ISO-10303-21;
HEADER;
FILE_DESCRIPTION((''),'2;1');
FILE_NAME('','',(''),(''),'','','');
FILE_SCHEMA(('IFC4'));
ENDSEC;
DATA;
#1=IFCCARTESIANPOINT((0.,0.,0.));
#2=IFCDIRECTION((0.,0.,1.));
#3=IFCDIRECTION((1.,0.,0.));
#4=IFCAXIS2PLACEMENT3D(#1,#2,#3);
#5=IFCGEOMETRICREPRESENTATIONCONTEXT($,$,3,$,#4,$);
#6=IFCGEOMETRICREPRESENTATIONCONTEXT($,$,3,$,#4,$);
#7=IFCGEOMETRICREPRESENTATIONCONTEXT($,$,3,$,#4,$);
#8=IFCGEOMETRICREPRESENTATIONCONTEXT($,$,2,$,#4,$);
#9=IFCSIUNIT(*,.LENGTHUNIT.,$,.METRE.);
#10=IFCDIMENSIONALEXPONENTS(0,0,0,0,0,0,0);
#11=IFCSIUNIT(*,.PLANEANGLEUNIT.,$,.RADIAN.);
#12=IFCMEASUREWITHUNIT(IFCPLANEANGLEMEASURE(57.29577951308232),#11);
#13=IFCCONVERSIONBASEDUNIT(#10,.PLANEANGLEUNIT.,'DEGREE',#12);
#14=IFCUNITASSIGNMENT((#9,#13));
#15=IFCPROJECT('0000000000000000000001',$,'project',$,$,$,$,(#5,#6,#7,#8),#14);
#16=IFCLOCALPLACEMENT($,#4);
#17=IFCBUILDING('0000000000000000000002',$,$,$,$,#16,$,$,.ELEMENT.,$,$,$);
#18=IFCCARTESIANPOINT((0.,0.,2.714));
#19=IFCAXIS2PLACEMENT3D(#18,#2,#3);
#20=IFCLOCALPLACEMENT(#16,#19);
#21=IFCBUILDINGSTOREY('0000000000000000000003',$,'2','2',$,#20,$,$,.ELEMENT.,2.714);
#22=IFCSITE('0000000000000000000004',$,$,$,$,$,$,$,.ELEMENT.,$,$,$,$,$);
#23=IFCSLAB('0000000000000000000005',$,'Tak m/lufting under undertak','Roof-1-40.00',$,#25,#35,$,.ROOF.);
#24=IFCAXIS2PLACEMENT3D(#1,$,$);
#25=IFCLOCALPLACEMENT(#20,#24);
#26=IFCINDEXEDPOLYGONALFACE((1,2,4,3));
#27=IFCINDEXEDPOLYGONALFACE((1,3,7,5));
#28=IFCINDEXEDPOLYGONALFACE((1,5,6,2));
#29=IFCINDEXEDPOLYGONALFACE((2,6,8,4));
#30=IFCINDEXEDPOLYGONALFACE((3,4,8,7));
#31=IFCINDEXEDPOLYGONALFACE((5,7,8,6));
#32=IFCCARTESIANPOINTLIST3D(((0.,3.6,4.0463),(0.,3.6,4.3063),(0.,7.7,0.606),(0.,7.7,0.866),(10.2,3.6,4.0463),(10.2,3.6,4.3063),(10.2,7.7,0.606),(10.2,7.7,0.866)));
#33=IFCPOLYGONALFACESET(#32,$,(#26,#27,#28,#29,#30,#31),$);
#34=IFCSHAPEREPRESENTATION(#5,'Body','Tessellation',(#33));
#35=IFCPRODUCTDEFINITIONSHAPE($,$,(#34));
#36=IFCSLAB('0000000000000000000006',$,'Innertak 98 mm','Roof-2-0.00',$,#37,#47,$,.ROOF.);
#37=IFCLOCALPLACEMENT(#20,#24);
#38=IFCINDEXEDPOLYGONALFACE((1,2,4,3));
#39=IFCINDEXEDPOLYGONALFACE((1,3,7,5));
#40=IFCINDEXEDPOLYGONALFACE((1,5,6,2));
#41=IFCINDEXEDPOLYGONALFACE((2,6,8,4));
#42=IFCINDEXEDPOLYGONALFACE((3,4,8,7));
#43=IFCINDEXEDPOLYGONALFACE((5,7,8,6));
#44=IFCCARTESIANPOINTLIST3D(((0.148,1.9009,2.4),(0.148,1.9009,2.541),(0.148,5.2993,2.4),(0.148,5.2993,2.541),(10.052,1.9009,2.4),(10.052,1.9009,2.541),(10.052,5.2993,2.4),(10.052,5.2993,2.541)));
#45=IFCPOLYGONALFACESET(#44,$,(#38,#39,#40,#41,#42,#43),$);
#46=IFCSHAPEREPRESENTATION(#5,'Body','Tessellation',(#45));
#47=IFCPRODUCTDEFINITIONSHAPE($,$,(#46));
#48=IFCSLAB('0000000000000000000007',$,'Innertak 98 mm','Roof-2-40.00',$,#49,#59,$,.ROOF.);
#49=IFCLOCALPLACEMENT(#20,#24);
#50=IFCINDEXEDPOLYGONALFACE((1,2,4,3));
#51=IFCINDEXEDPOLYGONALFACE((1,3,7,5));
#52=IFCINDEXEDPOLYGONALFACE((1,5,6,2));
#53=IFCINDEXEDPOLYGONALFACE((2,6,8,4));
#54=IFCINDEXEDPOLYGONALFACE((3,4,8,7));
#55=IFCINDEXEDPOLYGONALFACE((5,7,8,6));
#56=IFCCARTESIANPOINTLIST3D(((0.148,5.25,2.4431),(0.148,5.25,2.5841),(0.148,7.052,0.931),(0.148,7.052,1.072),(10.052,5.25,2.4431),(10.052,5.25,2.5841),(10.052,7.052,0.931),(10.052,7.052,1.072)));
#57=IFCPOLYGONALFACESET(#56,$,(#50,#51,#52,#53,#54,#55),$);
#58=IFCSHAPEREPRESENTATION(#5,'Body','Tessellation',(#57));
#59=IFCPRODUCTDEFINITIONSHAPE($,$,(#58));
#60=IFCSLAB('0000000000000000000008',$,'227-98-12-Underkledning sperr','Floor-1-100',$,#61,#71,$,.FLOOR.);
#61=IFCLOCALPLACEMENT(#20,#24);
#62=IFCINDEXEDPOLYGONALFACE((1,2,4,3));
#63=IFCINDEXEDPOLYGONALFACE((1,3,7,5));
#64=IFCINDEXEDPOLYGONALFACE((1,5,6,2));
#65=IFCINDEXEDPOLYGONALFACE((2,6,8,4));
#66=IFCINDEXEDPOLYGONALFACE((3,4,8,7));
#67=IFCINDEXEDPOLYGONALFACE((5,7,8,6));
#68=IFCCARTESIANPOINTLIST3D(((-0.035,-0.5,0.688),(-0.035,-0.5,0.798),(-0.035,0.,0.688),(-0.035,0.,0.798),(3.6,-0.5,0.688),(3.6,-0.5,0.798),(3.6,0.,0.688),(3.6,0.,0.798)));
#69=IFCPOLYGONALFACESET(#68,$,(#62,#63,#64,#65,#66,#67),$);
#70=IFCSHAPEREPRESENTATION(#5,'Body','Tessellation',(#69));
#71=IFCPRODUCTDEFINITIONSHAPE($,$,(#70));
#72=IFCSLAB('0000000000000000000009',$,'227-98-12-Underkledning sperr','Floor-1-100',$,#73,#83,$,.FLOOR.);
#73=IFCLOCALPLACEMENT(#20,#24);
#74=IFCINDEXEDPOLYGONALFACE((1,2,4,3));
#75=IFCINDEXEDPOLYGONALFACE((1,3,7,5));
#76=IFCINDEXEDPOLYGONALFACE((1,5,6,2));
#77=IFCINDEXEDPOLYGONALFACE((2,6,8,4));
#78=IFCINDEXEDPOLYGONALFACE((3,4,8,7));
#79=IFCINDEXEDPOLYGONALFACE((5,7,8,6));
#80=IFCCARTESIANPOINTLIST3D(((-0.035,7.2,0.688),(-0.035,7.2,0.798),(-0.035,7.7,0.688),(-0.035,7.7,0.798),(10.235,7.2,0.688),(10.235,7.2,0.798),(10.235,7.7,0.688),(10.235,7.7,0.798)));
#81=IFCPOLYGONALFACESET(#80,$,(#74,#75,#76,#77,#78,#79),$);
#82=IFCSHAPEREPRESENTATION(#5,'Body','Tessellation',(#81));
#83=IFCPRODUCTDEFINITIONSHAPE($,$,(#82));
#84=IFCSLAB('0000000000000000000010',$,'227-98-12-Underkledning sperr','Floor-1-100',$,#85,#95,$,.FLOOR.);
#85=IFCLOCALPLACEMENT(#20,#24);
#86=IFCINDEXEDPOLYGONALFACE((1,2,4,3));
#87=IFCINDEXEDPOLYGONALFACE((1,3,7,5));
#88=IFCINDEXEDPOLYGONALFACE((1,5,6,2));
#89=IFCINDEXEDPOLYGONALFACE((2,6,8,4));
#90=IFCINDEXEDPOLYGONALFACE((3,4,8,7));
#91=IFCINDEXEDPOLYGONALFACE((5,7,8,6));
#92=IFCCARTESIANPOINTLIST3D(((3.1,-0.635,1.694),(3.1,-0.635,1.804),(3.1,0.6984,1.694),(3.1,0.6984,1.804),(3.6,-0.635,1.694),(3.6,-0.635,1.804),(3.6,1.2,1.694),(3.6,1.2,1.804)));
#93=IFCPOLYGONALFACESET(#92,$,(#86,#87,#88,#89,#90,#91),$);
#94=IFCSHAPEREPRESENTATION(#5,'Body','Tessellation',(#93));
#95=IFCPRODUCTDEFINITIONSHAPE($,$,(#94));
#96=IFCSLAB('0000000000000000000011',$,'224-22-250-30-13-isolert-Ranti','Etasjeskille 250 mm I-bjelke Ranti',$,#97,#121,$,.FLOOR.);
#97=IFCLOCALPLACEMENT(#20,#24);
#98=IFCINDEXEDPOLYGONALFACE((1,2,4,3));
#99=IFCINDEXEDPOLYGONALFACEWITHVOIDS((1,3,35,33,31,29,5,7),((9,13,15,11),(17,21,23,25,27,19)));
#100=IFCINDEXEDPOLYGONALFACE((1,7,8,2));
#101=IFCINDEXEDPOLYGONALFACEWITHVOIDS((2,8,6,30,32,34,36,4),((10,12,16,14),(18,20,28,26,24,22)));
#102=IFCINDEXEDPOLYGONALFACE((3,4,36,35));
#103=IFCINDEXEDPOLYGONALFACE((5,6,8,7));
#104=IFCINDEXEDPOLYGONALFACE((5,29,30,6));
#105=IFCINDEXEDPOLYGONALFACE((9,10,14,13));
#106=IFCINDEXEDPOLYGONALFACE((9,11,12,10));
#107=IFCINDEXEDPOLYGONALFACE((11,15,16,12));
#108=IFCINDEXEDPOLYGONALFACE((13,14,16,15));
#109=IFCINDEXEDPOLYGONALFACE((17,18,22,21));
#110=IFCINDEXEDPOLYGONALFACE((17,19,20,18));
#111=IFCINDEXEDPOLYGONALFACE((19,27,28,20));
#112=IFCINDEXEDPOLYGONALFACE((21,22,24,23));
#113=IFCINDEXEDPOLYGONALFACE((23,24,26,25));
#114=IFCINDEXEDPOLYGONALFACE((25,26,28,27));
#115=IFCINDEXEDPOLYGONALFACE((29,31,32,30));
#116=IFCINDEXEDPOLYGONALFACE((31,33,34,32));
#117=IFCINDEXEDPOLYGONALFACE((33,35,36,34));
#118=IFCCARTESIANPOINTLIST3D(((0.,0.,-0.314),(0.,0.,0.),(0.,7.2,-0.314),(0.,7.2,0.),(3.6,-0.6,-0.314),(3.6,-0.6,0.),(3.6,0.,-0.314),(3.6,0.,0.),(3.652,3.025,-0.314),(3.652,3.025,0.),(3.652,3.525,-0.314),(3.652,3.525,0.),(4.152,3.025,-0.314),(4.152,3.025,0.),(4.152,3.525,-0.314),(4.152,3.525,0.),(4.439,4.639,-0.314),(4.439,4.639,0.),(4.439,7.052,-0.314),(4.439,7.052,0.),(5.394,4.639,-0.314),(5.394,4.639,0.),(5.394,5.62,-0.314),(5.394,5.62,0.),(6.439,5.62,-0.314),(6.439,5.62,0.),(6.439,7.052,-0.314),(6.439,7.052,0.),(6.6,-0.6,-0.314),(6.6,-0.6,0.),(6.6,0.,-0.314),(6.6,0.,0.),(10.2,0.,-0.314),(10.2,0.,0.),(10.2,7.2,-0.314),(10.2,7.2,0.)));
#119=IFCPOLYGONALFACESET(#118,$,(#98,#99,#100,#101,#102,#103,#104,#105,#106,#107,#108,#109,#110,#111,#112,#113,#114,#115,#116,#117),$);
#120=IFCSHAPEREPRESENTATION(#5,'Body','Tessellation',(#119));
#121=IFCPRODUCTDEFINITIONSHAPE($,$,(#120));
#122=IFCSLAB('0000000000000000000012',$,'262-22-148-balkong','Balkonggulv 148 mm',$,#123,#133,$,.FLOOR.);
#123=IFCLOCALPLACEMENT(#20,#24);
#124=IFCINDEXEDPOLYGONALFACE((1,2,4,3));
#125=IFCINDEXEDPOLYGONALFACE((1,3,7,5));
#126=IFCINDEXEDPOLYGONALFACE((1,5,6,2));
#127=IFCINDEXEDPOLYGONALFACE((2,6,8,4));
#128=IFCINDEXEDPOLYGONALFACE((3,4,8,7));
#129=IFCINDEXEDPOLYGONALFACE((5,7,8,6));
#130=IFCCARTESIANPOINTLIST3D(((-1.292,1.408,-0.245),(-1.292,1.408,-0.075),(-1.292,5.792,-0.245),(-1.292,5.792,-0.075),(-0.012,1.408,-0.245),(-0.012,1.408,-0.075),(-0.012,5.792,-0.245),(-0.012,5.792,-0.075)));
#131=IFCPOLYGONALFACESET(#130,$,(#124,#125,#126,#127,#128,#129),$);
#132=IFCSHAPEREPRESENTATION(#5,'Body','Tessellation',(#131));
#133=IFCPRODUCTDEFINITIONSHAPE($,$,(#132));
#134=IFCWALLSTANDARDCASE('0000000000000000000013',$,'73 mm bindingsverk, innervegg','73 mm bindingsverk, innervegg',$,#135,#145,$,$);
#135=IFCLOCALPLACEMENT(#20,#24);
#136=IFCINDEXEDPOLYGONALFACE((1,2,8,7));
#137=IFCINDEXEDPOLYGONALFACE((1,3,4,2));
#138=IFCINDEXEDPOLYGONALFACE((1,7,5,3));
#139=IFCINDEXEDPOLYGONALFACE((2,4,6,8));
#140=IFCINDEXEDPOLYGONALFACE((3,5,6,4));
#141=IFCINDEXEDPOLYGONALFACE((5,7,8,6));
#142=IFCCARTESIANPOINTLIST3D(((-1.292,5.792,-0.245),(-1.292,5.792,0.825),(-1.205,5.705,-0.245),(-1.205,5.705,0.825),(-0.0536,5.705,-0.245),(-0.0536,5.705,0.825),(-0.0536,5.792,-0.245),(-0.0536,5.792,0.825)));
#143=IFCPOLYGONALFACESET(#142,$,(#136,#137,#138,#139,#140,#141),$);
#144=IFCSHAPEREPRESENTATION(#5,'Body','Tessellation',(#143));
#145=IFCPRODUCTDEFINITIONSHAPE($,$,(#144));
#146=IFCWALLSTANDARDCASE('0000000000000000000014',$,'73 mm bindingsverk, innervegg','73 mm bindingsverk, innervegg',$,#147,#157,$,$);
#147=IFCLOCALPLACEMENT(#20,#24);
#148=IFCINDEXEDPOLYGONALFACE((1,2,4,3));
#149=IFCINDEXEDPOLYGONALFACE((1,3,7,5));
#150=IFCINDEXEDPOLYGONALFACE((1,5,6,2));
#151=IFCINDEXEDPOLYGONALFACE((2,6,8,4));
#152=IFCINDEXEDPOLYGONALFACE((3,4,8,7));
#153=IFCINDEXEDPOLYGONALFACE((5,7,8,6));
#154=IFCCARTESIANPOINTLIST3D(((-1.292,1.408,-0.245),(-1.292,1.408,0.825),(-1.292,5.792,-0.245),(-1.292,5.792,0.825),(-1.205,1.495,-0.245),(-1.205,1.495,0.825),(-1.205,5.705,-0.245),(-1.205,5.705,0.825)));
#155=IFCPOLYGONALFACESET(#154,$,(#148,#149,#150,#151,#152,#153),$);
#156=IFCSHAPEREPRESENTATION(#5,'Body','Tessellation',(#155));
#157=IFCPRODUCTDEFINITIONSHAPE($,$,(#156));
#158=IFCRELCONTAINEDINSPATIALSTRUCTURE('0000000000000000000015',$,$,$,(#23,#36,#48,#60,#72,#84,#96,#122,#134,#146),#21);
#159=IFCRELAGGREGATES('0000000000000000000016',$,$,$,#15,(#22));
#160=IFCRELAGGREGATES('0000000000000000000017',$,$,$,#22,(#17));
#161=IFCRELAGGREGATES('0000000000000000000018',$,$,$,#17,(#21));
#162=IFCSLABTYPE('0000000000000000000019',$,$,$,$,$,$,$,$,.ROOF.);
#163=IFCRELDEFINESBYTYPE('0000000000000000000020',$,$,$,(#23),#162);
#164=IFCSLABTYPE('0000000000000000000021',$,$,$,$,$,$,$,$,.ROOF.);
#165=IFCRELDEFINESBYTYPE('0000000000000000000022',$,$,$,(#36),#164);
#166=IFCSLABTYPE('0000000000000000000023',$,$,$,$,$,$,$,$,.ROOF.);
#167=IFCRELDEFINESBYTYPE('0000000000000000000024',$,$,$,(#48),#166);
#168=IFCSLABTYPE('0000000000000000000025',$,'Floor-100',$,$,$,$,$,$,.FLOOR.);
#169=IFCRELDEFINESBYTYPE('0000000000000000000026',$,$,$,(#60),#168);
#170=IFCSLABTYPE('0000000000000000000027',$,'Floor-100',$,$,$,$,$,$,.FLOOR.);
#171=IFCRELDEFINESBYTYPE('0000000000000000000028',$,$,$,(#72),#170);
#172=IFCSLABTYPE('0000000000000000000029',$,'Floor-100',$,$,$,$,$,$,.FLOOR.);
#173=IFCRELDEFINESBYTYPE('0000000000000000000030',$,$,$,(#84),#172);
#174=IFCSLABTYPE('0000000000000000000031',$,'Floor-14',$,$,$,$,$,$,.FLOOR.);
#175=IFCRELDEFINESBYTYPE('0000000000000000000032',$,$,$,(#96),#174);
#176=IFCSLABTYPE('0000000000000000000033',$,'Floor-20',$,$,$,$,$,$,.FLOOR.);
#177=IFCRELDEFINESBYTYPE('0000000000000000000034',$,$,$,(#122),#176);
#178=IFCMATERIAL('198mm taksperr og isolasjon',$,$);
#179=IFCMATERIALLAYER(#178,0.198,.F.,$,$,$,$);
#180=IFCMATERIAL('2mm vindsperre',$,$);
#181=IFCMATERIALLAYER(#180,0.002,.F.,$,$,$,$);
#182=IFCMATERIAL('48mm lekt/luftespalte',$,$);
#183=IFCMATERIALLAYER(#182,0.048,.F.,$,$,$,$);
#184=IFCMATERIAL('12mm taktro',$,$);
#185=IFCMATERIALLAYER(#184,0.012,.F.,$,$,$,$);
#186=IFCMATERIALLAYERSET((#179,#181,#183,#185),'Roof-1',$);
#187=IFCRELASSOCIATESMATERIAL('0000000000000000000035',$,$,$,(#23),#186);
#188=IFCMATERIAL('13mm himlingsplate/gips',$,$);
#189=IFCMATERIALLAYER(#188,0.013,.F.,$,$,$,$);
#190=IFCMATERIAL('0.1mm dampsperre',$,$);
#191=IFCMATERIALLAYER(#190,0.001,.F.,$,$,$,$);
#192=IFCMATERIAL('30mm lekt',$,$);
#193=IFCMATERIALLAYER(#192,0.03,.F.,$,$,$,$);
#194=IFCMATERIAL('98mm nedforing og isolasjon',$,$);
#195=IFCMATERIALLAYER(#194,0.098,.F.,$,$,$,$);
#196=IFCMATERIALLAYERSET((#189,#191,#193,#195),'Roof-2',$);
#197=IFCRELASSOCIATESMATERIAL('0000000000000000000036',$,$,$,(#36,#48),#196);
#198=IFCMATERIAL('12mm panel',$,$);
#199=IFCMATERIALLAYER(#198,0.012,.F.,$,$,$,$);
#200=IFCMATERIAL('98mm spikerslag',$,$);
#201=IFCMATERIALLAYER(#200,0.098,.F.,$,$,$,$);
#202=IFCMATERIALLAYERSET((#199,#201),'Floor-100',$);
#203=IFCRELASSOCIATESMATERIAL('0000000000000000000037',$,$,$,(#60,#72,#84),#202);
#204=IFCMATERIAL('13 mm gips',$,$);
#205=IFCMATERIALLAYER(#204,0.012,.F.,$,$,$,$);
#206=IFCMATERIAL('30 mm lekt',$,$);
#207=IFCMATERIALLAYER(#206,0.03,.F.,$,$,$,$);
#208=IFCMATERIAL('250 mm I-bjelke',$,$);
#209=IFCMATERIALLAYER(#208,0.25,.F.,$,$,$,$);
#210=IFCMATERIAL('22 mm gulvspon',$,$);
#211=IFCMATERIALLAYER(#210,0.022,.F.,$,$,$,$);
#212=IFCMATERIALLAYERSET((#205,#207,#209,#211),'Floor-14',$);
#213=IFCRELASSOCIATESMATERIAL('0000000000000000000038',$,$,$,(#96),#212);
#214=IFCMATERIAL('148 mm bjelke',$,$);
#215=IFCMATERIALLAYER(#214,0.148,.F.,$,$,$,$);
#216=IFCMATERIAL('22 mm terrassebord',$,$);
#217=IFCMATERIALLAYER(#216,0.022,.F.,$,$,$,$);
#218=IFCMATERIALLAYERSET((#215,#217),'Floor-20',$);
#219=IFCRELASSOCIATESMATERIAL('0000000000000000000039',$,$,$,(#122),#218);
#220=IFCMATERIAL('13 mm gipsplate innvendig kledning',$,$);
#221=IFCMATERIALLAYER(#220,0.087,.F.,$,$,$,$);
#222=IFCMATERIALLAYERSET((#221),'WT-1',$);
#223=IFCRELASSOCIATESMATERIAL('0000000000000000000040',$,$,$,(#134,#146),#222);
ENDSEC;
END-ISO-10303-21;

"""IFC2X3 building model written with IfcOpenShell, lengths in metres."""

from ifc_helpers import new_model, entity, si_unit, converted_unit, frame, origin_with_axes, place, context, project, spatial, polyline, outline, extrude, material, layer, layer_set, layer_usage, type_object, element, save


model = new_model("IFC2X3")

# Units and contexts
context_of_model_1 = context(None, 3, world=origin_with_axes())
context_of_model_2 = context(None, 3, world=origin_with_axes())
context_of_model_3 = context(None, 3, world=origin_with_axes())
context_of_model_4 = context(None, 2, world=origin_with_axes())
ifc_project = project(units=[si_unit("LENGTHUNIT", "METRE"), converted_unit("PLANEANGLEUNIT", "DEGREE", entity("IfcPlaneAngleMeasure", 57.29577951308232), si_unit("PLANEANGLEUNIT", "RADIAN"), dimensions=[0, 0, 0, 0, 0, 0, 0])], contexts=[context_of_model_1, context_of_model_2, context_of_model_3, context_of_model_4])

# Site, building, storey
site = spatial("IfcSite", under=ifc_project, CompositionType="ELEMENT")
building_placement = place(None, origin_with_axes())
building = spatial("IfcBuilding", under=site, at=building_placement, CompositionType="ELEMENT")
storey_placement = place(building_placement, frame((0.0, 0.0, 2.714), z_axis=(0.0, 0.0, 1.0), x_axis=(1.0, 0.0, 0.0)))
storey = spatial("IfcBuildingStorey", under=building, at=storey_placement, Name="2", Description="2", CompositionType="ELEMENT", Elevation=2.714)

# Slabs
ifc_material_1 = material(Name="198mm taksperr og isolasjon")
ifc_layer_1 = layer(ifc_material_1, 0.198, ventilated=False)
ifc_material_2 = material(Name="2mm vindsperre")
ifc_layer_2 = layer(ifc_material_2, 0.002, ventilated=False)
ifc_material_3 = material(Name="48mm lekt/luftespalte")
ifc_layer_3 = layer(ifc_material_3, 0.048, ventilated=False)
ifc_material_4 = material(Name="12mm taktro")
ifc_layer_4 = layer(ifc_material_4, 0.012, ventilated=False)
ifc_layer_set_1 = layer_set([ifc_layer_1, ifc_layer_2, ifc_layer_3, ifc_layer_4], Name="Roof-1")
ifc_layer_usage_1 = layer_usage(ifc_layer_set_1, "AXIS3", "NEGATIVE", 0.0)
slab_type_1 = type_object("IfcSlabType", PredefinedType="ROOF")
slab_1_placement = place(storey_placement, frame((0.0, 3.6, 4.0463), z_axis=(0.0, 0.642788, 0.766044), x_axis=(1.0, 0.0, 0.0)))
element("IfcSlab", 1, at=slab_1_placement, inside=storey, type_object=slab_type_1, material=ifc_layer_usage_1, Name="Tak m/lufting under undertak", Description="Roof-1-40.00", PredefinedType="ROOF", context=context_of_model_1, shape_type="SweptSolid", body=[
    extrude(outline(polyline([(0.0, 0.0), (5.3522, 0.0), (5.3522, 10.2), (0.0, 10.2), (0.0, 0.0)])), frame((0.0, 0.0, 0.0), z_axis=(0.0, 0.0, -1.0), x_axis=(0.0, 1.0, 0.0)), (-0.642788, 0.0, -0.766044), 0.26),
])
ifc_material_5 = material(Name="13mm himlingsplate/gips")
ifc_layer_5 = layer(ifc_material_5, 0.013, ventilated=False)
ifc_material_6 = material(Name="0.1mm dampsperre")
ifc_layer_6 = layer(ifc_material_6, 0.001, ventilated=False)
ifc_material_7 = material(Name="30mm lekt")
ifc_layer_7 = layer(ifc_material_7, 0.03, ventilated=False)
ifc_material_8 = material(Name="98mm nedforing og isolasjon")
ifc_layer_8 = layer(ifc_material_8, 0.098, ventilated=False)
ifc_layer_set_2 = layer_set([ifc_layer_5, ifc_layer_6, ifc_layer_7, ifc_layer_8], Name="Roof-2")
ifc_layer_usage_2 = layer_usage(ifc_layer_set_2, "AXIS3", "NEGATIVE", 0.0)
slab_type_2 = type_object("IfcSlabType", PredefinedType="ROOF")
slab_2_placement = place(storey_placement, frame((0.148, 1.9009, 2.4), z_axis=(0.0, 0.0, 1.0), x_axis=(1.0, 0.0, 0.0)))
element("IfcSlab", 2, at=slab_2_placement, inside=storey, type_object=slab_type_2, material=ifc_layer_usage_2, Name="Innertak 98 mm", Description="Roof-2-0.00", PredefinedType="ROOF", context=context_of_model_1, shape_type="SweptSolid", body=[
    extrude(outline(polyline([(0.0, 0.0), (9.904, 0.0), (9.904, 3.3984), (0.0, 3.3984), (0.0, 0.0)])), origin_with_axes(), (0.0, 0.0, 1.0), 0.141),
])
slab_type_3 = type_object("IfcSlabType", PredefinedType="ROOF")
slab_3_placement = place(storey_placement, frame((0.148, 5.25, 2.4431), z_axis=(0.0, 0.642788, 0.766044), x_axis=(1.0, 0.0, 0.0)))
element("IfcSlab", 3, at=slab_3_placement, inside=storey, type_object=slab_type_3, material=ifc_layer_usage_2, Name="Innertak 98 mm", Description="Roof-2-40.00", PredefinedType="ROOF", context=context_of_model_1, shape_type="SweptSolid", body=[
    extrude(outline(polyline([(0.0, 0.0), (9.904, 0.0), (9.904, 2.3523), (0.0, 2.3523), (0.0, 0.0)])), frame((0.0, 0.0, 0.0), z_axis=(0.0, 0.0, 1.0), x_axis=(1.0, 0.0, 0.0)), (0.0, -0.642788, 0.766044), 0.141),
])
ifc_material_9 = material(Name="12mm panel")
ifc_layer_9 = layer(ifc_material_9, 0.012, ventilated=False)
ifc_material_10 = material(Name="98mm spikerslag")
ifc_layer_10 = layer(ifc_material_10, 0.098, ventilated=False)
ifc_layer_set_3 = layer_set([ifc_layer_9, ifc_layer_10], Name="Floor-100")
ifc_layer_usage_3 = layer_usage(ifc_layer_set_3, "AXIS3", "NEGATIVE", 0.0)
slab_type_4 = type_object("IfcSlabType", Name="Floor-100", PredefinedType="FLOOR")
slab_4_placement = place(storey_placement, frame((-0.035, -0.5, 0.688), z_axis=(0.0, 0.0, 1.0), x_axis=(1.0, 0.0, 0.0)))
element("IfcSlab", 4, at=slab_4_placement, inside=storey, type_object=slab_type_4, material=ifc_layer_usage_3, Name="227-98-12-Underkledning sperr", Description="Floor-1-100", PredefinedType="FLOOR", context=context_of_model_1, shape_type="SweptSolid", body=[
    extrude(outline(polyline([(0.0, 0.0), (3.635, 0.0), (3.635, 0.5), (0.0, 0.5), (0.0, 0.0)])), origin_with_axes(), (0.0, 0.0, 1.0), 0.11),
])
slab_type_5 = type_object("IfcSlabType", Name="Floor-100", PredefinedType="FLOOR")
slab_5_placement = place(storey_placement, frame((-0.035, 7.2, 0.688), z_axis=(0.0, 0.0, 1.0), x_axis=(1.0, 0.0, 0.0)))
element("IfcSlab", 5, at=slab_5_placement, inside=storey, type_object=slab_type_5, material=ifc_layer_usage_3, Name="227-98-12-Underkledning sperr", Description="Floor-1-100", PredefinedType="FLOOR", context=context_of_model_1, shape_type="SweptSolid", body=[
    extrude(outline(polyline([(0.0, 0.0), (10.27, 0.0), (10.27, 0.5), (0.0, 0.5), (0.0, 0.0)])), origin_with_axes(), (0.0, 0.0, 1.0), 0.11),
])
slab_type_6 = type_object("IfcSlabType", Name="Floor-100", PredefinedType="FLOOR")
slab_6_placement = place(storey_placement, frame((3.1, -0.635, 1.694), z_axis=(0.0, 0.0, 1.0), x_axis=(1.0, 0.0, 0.0)))
element("IfcSlab", 6, at=slab_6_placement, inside=storey, type_object=slab_type_6, material=ifc_layer_usage_3, Name="227-98-12-Underkledning sperr", Description="Floor-1-100", PredefinedType="FLOOR", context=context_of_model_1, shape_type="SweptSolid", body=[
    extrude(outline(polyline([(0.0, 0.0), (0.5, 0.0), (0.5, 1.835), (0.0, 1.3334), (0.0, 0.0)])), origin_with_axes(), (0.0, 0.0, 1.0), 0.11),
])

# Slab, openings
ifc_material_11 = material(Name="13 mm gips")
ifc_layer_11 = layer(ifc_material_11, 0.012, ventilated=False)
ifc_material_12 = material(Name="30 mm lekt")
ifc_layer_12 = layer(ifc_material_12, 0.03, ventilated=False)
ifc_material_13 = material(Name="250 mm I-bjelke")
ifc_layer_13 = layer(ifc_material_13, 0.25, ventilated=False)
ifc_material_14 = material(Name="22 mm gulvspon")
ifc_layer_14 = layer(ifc_material_14, 0.022, ventilated=False)
ifc_layer_set_4 = layer_set([ifc_layer_11, ifc_layer_12, ifc_layer_13, ifc_layer_14], Name="Floor-14")
ifc_layer_usage_4 = layer_usage(ifc_layer_set_4, "AXIS3", "NEGATIVE", 0.0)
slab_type_7 = type_object("IfcSlabType", Name="Floor-14", PredefinedType="FLOOR")
slab_7_placement = place(storey_placement, frame((0.0, 0.0, -0.314), z_axis=(0.0, 0.0, 1.0), x_axis=(1.0, 0.0, 0.0)))
slab_7 = element("IfcSlab", 7, at=slab_7_placement, inside=storey, type_object=slab_type_7, material=ifc_layer_usage_4, Name="224-22-250-30-13-isolert-Ranti", Description="Etasjeskille 250 mm I-bjelke Ranti", PredefinedType="FLOOR", context=context_of_model_1, shape_type="SweptSolid", body=[
    extrude(outline(polyline([(0.0, 0.0), (3.6, 0.0), (3.6, 0.6), (6.6, 0.6), (6.6, 0.0), (10.2, 0.0), (10.2, -7.2), (0.0, -7.2), (0.0, 0.0)])), frame((0.0, 0.0, 0.0), z_axis=(0.0, 0.0, -1.0), x_axis=(1.0, 0.0, 0.0)), (0.0, 0.0, -1.0), 0.314),
])
opening_1_placement = place(slab_7_placement, frame((3.652, 3.025, 0.0), z_axis=(0.0, 0.0, 1.0), x_axis=(1.0, 0.0, 0.0)))
element("IfcOpeningElement", 8, at=opening_1_placement, inside=storey, cuts=slab_7, context=context_of_model_1, shape_type="SweptSolid", body=[
    extrude(outline(polyline([(0.0, 0.0), (0.5, 0.0), (0.5, 0.5), (0.0, 0.5), (0.0, 0.0)])), origin_with_axes(), (0.0, 0.0, 1.0), 0.314),
])
opening_2_placement = place(slab_7_placement, frame((4.439, 4.639, 0.0), z_axis=(0.0, 0.0, 1.0), x_axis=(1.0, 0.0, 0.0)))
element("IfcOpeningElement", 9, at=opening_2_placement, inside=storey, cuts=slab_7, context=context_of_model_1, shape_type="SweptSolid", body=[
    extrude(outline(polyline([(0.0, 0.0), (0.955, 0.0), (0.955, 0.981), (2.0, 0.981), (2.0, 2.413), (0.0, 2.413), (0.0, 0.0)])), frame((0.0, 0.0, 0.0), z_axis=(0.0, 0.0, 1.0), x_axis=(1.0, 0.0, 0.0)), (0.0, 0.0, 1.0), 0.314),
])

# Slab
ifc_material_15 = material(Name="148 mm bjelke")
ifc_layer_15 = layer(ifc_material_15, 0.148, ventilated=False)
ifc_material_16 = material(Name="22 mm terrassebord")
ifc_layer_16 = layer(ifc_material_16, 0.022, ventilated=False)
ifc_layer_set_5 = layer_set([ifc_layer_15, ifc_layer_16], Name="Floor-20")
ifc_layer_usage_5 = layer_usage(ifc_layer_set_5, "AXIS3", "NEGATIVE", 0.0)
slab_type_8 = type_object("IfcSlabType", Name="Floor-20", PredefinedType="FLOOR")
slab_8_placement = place(storey_placement, frame((-1.292, 1.408, -0.245), z_axis=(0.0, 0.0, 1.0), x_axis=(1.0, 0.0, 0.0)))
element("IfcSlab", 10, at=slab_8_placement, inside=storey, type_object=slab_type_8, material=ifc_layer_usage_5, Name="262-22-148-balkong", Description="Balkonggulv 148 mm", PredefinedType="FLOOR", context=context_of_model_1, shape_type="SweptSolid", body=[
    extrude(outline(polyline([(0.0, 0.0), (1.28, 0.0), (1.28, 4.384), (0.0, 4.384), (0.0, 0.0)])), origin_with_axes(), (0.0, 0.0, 1.0), 0.17),
])

# Walls
ifc_material_17 = material(Name="13 mm gipsplate innvendig kledning")
ifc_layer_17 = layer(ifc_material_17, 0.087, ventilated=False)
ifc_layer_set_6 = layer_set([ifc_layer_17], Name="WT-1")
ifc_layer_usage_6 = layer_usage(ifc_layer_set_6, "AXIS2", "POSITIVE", 0.0)
wall_1_placement = place(storey_placement, frame((-0.0536, 5.792, -0.245), z_axis=(0.0, 0.0, 1.0), x_axis=(-1.0, 0.0, 0.0)))
element("IfcWallStandardCase", 11, at=wall_1_placement, inside=storey, material=ifc_layer_usage_6, Name="73 mm bindingsverk, innervegg", Description="73 mm bindingsverk, innervegg", context=context_of_model_1, shape_type="SweptSolid", body=[
    extrude(outline(polyline([(0.0, 0.0), (1.2384, 0.0), (1.1514, 0.087), (0.0, 0.087), (0.0, 0.0)])), frame((0.0, 0.0, 0.0), z_axis=(0.0, 0.0, 1.0), x_axis=(1.0, 0.0, 0.0)), (0.0, 0.0, 1.0), 1.07),
])
wall_2_placement = place(storey_placement, frame((-1.292, 5.792, -0.245), z_axis=(0.0, 0.0, 1.0), x_axis=(0.0, -1.0, 0.0)))
element("IfcWallStandardCase", 12, at=wall_2_placement, inside=storey, material=ifc_layer_usage_6, Name="73 mm bindingsverk, innervegg", Description="73 mm bindingsverk, innervegg", context=context_of_model_1, shape_type="SweptSolid", body=[
    extrude(outline(polyline([(0.0, 0.0), (4.384, 0.0), (4.297, 0.087), (0.087, 0.087), (0.0, 0.0)])), frame((0.0, 0.0, 0.0), z_axis=(0.0, 0.0, 1.0), x_axis=(1.0, -0.000003, 0.0)), (0.0, 0.0, 1.0), 1.07),
])

save(model, "model.ifc")
